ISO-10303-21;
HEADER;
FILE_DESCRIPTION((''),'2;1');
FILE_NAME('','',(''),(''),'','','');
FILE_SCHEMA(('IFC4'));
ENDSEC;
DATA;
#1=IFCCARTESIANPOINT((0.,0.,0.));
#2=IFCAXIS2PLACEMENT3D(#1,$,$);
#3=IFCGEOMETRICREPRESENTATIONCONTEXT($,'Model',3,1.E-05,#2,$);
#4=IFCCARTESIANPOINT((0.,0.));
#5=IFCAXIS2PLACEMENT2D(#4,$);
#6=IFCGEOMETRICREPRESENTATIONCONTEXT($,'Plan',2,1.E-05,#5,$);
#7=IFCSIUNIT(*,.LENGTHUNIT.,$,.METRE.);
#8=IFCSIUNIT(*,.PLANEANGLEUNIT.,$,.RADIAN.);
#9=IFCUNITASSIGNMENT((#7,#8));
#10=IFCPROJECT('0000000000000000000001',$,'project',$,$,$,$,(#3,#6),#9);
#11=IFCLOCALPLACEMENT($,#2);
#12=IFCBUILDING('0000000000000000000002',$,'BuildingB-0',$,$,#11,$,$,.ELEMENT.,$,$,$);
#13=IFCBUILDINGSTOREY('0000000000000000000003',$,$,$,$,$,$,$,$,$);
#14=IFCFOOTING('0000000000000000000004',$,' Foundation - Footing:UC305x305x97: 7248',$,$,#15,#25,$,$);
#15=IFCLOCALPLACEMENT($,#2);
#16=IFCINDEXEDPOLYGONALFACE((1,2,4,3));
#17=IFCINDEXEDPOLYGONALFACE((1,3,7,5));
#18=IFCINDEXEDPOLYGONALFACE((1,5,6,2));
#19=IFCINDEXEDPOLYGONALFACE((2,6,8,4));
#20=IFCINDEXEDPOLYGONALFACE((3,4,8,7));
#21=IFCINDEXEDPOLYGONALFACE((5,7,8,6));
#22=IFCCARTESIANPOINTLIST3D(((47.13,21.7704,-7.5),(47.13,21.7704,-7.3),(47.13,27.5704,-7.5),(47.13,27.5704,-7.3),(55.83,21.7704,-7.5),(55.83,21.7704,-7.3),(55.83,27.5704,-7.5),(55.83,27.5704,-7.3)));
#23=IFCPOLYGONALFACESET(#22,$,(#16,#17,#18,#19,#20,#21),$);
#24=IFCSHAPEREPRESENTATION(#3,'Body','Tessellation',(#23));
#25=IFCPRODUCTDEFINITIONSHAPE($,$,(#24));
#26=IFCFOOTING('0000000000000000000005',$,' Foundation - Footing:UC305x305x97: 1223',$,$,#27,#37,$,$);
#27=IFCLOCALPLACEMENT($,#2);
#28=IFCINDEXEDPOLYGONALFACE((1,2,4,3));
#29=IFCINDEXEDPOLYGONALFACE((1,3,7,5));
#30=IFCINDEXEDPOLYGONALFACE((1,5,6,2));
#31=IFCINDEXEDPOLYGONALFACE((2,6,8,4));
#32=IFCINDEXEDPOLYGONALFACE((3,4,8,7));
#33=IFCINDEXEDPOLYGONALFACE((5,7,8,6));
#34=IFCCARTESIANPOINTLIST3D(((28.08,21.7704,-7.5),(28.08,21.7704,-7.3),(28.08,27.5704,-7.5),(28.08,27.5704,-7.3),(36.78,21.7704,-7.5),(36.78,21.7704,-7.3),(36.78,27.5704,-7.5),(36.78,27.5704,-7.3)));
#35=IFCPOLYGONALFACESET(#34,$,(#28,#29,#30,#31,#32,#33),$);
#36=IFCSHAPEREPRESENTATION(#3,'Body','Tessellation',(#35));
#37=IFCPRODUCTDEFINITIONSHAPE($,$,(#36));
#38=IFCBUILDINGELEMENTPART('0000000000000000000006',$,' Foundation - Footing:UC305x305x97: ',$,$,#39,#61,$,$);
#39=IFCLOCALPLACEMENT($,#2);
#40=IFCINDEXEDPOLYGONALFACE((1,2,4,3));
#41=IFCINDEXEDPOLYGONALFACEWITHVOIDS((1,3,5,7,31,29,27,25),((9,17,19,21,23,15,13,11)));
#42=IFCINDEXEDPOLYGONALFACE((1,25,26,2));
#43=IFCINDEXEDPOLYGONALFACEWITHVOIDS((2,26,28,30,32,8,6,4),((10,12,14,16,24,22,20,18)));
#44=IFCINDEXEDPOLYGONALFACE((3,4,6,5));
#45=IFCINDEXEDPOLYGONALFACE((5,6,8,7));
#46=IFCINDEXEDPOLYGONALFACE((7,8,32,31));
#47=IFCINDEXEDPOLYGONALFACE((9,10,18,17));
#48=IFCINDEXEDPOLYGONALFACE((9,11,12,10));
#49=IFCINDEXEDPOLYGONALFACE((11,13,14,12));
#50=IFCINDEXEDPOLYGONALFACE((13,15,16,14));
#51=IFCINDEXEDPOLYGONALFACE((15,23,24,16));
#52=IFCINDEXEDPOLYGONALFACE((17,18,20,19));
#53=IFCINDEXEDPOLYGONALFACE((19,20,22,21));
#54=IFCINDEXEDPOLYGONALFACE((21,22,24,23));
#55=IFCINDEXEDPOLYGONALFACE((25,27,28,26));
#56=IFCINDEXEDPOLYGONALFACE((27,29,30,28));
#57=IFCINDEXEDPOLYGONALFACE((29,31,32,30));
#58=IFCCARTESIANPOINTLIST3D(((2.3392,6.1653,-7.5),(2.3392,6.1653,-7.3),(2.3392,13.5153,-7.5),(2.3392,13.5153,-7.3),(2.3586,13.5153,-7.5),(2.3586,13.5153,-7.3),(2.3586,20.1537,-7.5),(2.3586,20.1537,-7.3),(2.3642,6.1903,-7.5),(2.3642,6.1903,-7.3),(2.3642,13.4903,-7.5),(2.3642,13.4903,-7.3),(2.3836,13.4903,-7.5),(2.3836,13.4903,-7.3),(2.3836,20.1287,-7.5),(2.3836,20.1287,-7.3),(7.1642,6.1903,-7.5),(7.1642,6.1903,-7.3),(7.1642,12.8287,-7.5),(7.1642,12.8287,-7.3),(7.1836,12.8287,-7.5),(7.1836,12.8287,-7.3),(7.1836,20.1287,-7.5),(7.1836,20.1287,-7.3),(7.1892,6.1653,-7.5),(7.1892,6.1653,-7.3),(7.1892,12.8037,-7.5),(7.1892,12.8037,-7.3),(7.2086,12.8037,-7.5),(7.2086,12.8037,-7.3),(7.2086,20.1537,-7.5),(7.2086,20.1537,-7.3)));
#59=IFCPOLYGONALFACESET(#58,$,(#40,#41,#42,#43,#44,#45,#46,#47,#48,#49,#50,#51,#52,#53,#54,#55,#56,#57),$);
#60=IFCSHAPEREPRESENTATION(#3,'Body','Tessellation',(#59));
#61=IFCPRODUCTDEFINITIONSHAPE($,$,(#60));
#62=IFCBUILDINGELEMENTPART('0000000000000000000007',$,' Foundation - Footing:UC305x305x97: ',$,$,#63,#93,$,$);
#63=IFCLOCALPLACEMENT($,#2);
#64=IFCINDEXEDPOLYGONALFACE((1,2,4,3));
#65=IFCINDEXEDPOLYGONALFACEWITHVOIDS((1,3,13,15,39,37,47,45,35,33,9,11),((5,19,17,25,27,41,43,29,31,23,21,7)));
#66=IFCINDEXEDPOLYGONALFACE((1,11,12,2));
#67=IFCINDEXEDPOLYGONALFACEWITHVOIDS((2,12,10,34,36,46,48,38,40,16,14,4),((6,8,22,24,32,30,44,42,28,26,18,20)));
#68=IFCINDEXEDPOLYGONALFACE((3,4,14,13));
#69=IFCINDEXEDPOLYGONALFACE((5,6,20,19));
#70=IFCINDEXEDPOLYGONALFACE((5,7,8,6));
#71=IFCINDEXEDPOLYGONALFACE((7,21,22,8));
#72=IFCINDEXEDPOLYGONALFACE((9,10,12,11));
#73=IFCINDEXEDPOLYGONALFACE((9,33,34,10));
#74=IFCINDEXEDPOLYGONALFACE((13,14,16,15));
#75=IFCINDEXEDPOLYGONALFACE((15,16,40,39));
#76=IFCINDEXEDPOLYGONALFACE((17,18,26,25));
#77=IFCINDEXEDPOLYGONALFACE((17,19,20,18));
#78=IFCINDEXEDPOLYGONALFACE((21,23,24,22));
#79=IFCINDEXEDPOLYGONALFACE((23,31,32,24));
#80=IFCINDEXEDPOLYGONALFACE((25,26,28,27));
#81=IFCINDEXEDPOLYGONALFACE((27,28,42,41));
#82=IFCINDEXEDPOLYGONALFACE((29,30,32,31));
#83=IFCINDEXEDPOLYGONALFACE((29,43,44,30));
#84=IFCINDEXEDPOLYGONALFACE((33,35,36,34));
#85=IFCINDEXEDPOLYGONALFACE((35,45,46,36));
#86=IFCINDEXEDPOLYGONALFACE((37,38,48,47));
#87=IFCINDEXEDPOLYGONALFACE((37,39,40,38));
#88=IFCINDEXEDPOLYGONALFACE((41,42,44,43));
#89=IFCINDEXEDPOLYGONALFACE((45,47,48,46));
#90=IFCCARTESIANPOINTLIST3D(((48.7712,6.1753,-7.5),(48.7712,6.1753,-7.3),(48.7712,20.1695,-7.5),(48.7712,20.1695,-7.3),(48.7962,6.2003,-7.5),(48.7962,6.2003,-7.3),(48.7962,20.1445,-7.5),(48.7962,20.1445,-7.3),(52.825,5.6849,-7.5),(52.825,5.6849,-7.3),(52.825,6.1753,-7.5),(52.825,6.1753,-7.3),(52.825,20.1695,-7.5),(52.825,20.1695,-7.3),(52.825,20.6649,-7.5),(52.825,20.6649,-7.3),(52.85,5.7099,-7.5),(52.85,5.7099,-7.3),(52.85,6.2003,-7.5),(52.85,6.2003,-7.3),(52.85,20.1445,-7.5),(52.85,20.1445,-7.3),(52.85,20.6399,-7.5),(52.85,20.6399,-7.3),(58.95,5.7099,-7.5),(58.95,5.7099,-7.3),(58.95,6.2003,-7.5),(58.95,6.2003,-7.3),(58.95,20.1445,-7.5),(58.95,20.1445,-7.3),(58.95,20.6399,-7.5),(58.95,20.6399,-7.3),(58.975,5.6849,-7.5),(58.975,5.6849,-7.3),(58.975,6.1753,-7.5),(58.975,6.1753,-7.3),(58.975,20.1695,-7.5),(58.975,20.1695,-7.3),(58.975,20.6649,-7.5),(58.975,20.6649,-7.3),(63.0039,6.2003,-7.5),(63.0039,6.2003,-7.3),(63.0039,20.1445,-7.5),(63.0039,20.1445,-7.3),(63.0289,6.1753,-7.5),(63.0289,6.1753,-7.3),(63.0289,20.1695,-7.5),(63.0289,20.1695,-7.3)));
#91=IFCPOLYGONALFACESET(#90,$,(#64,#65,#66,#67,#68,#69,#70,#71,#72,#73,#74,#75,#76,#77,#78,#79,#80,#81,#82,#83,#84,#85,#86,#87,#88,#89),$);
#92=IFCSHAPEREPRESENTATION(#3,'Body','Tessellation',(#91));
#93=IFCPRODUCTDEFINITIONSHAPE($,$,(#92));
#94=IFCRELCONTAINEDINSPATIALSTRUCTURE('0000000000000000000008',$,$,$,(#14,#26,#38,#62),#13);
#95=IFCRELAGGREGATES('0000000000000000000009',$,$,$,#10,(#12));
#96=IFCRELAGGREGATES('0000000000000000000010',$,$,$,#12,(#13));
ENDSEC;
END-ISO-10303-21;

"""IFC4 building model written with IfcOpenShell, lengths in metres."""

from ifc_helpers import new_model, si_unit, origin, origin_2d, place, context, project, spatial, polyline, outline, extrude, element, save


model = new_model("IFC4")

# Units and contexts
model_context = context("Model", 3, precision=1e-05, world=origin())
plan_context = context("Plan", 2, precision=1e-05, world=origin_2d())
ifc_project = project(units=[si_unit("LENGTHUNIT", "METRE"), si_unit("PLANEANGLEUNIT", "RADIAN")], contexts=[model_context, plan_context])

# Building, storey
building_placement = place(None, origin())
building = spatial("IfcBuilding", under=ifc_project, at=building_placement, Name="BuildingB-0", CompositionType="ELEMENT")
storey = spatial("IfcBuildingStorey", under=building)

# Footings
element("IfcFooting", 1, inside=storey, Name=" Foundation - Footing:UC305x305x97: 7248", context=model_context, shape_type="SweptSolid", body=[
    extrude(outline(polyline([(47.13, 21.7704, -7.5), (55.83, 21.7704, -7.5), (55.83, 27.5704, -7.5), (47.13, 27.5704, -7.5), (47.13, 21.7704, -7.5)])), None, (0.0, 0.0, 1.0), 0.2),
])
element("IfcFooting", 2, inside=storey, Name=" Foundation - Footing:UC305x305x97: 1223", context=model_context, shape_type="SweptSolid", body=[
    extrude(outline(polyline([(28.08, 21.7704, -7.5), (36.78, 21.7704, -7.5), (36.78, 27.5704, -7.5), (28.08, 27.5704, -7.5), (28.08, 21.7704, -7.5)])), None, (0.0, 0.0, 1.0), 0.2),
])

# Building element parts, openings
building_element_part_1 = element("IfcBuildingElementPart", 3, inside=storey, Name=" Foundation - Footing:UC305x305x97: ", context=model_context, shape_type="SweptSolid", body=[
    extrude(outline(polyline([(7.1892, 12.8037, -7.5), (7.2086, 12.8037, -7.5), (7.2086, 15.1899, -7.5), (7.2086, 20.1537, -7.5), (2.3586, 20.1537, -7.5), (2.3586, 17.04, -7.5), (2.3586, 13.5153, -7.5), (2.3392, 13.5153, -7.5), (2.3392, 9.16, -7.5), (2.3392, 6.1653, -7.5), (5.3245, 6.1653, -7.5), (7.1892, 6.1653, -7.5), (7.1892, 9.3099, -7.5), (7.1892, 12.8037, -7.5)])), None, (0.0, 0.0, 1.0), 0.2),
])
element("IfcOpeningElement", 4, inside=storey, cuts=building_element_part_1, context=model_context, shape_type="SweptSolid", body=[
    extrude(outline(polyline([(7.1642, 12.8287, -7.5), (7.1836, 12.8287, -7.5), (7.1836, 15.1899, -7.5), (7.1836, 20.1287, -7.5), (2.3836, 20.1287, -7.5), (2.3836, 17.04, -7.5), (2.3836, 13.4903, -7.5), (2.3642, 13.4903, -7.5), (2.3642, 9.16, -7.5), (2.3642, 6.1903, -7.5), (5.3245, 6.1903, -7.5), (7.1642, 6.1903, -7.5), (7.1642, 9.3099, -7.5), (7.1642, 12.8287, -7.5)])), None, (0.0, 0.0, 1.0), 0.2),
])
building_element_part_2 = element("IfcBuildingElementPart", 5, inside=storey, Name=" Foundation - Footing:UC305x305x97: ", context=model_context, shape_type="SweptSolid", body=[
    extrude(outline(polyline([(58.975, 5.6849, -7.5), (58.975, 6.1753, -7.5), (63.0289, 6.1753, -7.5), (63.0289, 20.1695, -7.5), (58.975, 20.1695, -7.5), (58.975, 20.6649, -7.5), (56.5291, 20.6649, -7.5), (54.9522, 20.6649, -7.5), (52.825, 20.6649, -7.5), (52.825, 20.1695, -7.5), (48.7712, 20.1695, -7.5), (48.7712, 6.1753, -7.5), (52.825, 6.1753, -7.5), (52.825, 5.6849, -7.5), (58.975, 5.6849, -7.5)])), None, (0.0, 0.0, 1.0), 0.2),
])
element("IfcOpeningElement", 6, inside=storey, cuts=building_element_part_2, context=model_context, shape_type="SweptSolid", body=[
    extrude(outline(polyline([(58.95, 5.7099, -7.5), (58.95, 6.2003, -7.5), (63.0039, 6.2003, -7.5), (63.0039, 20.1445, -7.5), (58.95, 20.1445, -7.5), (58.95, 20.6399, -7.5), (56.5291, 20.6399, -7.5), (54.9522, 20.6399, -7.5), (52.85, 20.6399, -7.5), (52.85, 20.1445, -7.5), (48.7962, 20.1445, -7.5), (48.7962, 6.2003, -7.5), (52.85, 6.2003, -7.5), (52.85, 5.7099, -7.5), (58.95, 5.7099, -7.5)])), None, (0.0, 0.0, 1.0), 0.2),
])

save(model, "model.ifc")
